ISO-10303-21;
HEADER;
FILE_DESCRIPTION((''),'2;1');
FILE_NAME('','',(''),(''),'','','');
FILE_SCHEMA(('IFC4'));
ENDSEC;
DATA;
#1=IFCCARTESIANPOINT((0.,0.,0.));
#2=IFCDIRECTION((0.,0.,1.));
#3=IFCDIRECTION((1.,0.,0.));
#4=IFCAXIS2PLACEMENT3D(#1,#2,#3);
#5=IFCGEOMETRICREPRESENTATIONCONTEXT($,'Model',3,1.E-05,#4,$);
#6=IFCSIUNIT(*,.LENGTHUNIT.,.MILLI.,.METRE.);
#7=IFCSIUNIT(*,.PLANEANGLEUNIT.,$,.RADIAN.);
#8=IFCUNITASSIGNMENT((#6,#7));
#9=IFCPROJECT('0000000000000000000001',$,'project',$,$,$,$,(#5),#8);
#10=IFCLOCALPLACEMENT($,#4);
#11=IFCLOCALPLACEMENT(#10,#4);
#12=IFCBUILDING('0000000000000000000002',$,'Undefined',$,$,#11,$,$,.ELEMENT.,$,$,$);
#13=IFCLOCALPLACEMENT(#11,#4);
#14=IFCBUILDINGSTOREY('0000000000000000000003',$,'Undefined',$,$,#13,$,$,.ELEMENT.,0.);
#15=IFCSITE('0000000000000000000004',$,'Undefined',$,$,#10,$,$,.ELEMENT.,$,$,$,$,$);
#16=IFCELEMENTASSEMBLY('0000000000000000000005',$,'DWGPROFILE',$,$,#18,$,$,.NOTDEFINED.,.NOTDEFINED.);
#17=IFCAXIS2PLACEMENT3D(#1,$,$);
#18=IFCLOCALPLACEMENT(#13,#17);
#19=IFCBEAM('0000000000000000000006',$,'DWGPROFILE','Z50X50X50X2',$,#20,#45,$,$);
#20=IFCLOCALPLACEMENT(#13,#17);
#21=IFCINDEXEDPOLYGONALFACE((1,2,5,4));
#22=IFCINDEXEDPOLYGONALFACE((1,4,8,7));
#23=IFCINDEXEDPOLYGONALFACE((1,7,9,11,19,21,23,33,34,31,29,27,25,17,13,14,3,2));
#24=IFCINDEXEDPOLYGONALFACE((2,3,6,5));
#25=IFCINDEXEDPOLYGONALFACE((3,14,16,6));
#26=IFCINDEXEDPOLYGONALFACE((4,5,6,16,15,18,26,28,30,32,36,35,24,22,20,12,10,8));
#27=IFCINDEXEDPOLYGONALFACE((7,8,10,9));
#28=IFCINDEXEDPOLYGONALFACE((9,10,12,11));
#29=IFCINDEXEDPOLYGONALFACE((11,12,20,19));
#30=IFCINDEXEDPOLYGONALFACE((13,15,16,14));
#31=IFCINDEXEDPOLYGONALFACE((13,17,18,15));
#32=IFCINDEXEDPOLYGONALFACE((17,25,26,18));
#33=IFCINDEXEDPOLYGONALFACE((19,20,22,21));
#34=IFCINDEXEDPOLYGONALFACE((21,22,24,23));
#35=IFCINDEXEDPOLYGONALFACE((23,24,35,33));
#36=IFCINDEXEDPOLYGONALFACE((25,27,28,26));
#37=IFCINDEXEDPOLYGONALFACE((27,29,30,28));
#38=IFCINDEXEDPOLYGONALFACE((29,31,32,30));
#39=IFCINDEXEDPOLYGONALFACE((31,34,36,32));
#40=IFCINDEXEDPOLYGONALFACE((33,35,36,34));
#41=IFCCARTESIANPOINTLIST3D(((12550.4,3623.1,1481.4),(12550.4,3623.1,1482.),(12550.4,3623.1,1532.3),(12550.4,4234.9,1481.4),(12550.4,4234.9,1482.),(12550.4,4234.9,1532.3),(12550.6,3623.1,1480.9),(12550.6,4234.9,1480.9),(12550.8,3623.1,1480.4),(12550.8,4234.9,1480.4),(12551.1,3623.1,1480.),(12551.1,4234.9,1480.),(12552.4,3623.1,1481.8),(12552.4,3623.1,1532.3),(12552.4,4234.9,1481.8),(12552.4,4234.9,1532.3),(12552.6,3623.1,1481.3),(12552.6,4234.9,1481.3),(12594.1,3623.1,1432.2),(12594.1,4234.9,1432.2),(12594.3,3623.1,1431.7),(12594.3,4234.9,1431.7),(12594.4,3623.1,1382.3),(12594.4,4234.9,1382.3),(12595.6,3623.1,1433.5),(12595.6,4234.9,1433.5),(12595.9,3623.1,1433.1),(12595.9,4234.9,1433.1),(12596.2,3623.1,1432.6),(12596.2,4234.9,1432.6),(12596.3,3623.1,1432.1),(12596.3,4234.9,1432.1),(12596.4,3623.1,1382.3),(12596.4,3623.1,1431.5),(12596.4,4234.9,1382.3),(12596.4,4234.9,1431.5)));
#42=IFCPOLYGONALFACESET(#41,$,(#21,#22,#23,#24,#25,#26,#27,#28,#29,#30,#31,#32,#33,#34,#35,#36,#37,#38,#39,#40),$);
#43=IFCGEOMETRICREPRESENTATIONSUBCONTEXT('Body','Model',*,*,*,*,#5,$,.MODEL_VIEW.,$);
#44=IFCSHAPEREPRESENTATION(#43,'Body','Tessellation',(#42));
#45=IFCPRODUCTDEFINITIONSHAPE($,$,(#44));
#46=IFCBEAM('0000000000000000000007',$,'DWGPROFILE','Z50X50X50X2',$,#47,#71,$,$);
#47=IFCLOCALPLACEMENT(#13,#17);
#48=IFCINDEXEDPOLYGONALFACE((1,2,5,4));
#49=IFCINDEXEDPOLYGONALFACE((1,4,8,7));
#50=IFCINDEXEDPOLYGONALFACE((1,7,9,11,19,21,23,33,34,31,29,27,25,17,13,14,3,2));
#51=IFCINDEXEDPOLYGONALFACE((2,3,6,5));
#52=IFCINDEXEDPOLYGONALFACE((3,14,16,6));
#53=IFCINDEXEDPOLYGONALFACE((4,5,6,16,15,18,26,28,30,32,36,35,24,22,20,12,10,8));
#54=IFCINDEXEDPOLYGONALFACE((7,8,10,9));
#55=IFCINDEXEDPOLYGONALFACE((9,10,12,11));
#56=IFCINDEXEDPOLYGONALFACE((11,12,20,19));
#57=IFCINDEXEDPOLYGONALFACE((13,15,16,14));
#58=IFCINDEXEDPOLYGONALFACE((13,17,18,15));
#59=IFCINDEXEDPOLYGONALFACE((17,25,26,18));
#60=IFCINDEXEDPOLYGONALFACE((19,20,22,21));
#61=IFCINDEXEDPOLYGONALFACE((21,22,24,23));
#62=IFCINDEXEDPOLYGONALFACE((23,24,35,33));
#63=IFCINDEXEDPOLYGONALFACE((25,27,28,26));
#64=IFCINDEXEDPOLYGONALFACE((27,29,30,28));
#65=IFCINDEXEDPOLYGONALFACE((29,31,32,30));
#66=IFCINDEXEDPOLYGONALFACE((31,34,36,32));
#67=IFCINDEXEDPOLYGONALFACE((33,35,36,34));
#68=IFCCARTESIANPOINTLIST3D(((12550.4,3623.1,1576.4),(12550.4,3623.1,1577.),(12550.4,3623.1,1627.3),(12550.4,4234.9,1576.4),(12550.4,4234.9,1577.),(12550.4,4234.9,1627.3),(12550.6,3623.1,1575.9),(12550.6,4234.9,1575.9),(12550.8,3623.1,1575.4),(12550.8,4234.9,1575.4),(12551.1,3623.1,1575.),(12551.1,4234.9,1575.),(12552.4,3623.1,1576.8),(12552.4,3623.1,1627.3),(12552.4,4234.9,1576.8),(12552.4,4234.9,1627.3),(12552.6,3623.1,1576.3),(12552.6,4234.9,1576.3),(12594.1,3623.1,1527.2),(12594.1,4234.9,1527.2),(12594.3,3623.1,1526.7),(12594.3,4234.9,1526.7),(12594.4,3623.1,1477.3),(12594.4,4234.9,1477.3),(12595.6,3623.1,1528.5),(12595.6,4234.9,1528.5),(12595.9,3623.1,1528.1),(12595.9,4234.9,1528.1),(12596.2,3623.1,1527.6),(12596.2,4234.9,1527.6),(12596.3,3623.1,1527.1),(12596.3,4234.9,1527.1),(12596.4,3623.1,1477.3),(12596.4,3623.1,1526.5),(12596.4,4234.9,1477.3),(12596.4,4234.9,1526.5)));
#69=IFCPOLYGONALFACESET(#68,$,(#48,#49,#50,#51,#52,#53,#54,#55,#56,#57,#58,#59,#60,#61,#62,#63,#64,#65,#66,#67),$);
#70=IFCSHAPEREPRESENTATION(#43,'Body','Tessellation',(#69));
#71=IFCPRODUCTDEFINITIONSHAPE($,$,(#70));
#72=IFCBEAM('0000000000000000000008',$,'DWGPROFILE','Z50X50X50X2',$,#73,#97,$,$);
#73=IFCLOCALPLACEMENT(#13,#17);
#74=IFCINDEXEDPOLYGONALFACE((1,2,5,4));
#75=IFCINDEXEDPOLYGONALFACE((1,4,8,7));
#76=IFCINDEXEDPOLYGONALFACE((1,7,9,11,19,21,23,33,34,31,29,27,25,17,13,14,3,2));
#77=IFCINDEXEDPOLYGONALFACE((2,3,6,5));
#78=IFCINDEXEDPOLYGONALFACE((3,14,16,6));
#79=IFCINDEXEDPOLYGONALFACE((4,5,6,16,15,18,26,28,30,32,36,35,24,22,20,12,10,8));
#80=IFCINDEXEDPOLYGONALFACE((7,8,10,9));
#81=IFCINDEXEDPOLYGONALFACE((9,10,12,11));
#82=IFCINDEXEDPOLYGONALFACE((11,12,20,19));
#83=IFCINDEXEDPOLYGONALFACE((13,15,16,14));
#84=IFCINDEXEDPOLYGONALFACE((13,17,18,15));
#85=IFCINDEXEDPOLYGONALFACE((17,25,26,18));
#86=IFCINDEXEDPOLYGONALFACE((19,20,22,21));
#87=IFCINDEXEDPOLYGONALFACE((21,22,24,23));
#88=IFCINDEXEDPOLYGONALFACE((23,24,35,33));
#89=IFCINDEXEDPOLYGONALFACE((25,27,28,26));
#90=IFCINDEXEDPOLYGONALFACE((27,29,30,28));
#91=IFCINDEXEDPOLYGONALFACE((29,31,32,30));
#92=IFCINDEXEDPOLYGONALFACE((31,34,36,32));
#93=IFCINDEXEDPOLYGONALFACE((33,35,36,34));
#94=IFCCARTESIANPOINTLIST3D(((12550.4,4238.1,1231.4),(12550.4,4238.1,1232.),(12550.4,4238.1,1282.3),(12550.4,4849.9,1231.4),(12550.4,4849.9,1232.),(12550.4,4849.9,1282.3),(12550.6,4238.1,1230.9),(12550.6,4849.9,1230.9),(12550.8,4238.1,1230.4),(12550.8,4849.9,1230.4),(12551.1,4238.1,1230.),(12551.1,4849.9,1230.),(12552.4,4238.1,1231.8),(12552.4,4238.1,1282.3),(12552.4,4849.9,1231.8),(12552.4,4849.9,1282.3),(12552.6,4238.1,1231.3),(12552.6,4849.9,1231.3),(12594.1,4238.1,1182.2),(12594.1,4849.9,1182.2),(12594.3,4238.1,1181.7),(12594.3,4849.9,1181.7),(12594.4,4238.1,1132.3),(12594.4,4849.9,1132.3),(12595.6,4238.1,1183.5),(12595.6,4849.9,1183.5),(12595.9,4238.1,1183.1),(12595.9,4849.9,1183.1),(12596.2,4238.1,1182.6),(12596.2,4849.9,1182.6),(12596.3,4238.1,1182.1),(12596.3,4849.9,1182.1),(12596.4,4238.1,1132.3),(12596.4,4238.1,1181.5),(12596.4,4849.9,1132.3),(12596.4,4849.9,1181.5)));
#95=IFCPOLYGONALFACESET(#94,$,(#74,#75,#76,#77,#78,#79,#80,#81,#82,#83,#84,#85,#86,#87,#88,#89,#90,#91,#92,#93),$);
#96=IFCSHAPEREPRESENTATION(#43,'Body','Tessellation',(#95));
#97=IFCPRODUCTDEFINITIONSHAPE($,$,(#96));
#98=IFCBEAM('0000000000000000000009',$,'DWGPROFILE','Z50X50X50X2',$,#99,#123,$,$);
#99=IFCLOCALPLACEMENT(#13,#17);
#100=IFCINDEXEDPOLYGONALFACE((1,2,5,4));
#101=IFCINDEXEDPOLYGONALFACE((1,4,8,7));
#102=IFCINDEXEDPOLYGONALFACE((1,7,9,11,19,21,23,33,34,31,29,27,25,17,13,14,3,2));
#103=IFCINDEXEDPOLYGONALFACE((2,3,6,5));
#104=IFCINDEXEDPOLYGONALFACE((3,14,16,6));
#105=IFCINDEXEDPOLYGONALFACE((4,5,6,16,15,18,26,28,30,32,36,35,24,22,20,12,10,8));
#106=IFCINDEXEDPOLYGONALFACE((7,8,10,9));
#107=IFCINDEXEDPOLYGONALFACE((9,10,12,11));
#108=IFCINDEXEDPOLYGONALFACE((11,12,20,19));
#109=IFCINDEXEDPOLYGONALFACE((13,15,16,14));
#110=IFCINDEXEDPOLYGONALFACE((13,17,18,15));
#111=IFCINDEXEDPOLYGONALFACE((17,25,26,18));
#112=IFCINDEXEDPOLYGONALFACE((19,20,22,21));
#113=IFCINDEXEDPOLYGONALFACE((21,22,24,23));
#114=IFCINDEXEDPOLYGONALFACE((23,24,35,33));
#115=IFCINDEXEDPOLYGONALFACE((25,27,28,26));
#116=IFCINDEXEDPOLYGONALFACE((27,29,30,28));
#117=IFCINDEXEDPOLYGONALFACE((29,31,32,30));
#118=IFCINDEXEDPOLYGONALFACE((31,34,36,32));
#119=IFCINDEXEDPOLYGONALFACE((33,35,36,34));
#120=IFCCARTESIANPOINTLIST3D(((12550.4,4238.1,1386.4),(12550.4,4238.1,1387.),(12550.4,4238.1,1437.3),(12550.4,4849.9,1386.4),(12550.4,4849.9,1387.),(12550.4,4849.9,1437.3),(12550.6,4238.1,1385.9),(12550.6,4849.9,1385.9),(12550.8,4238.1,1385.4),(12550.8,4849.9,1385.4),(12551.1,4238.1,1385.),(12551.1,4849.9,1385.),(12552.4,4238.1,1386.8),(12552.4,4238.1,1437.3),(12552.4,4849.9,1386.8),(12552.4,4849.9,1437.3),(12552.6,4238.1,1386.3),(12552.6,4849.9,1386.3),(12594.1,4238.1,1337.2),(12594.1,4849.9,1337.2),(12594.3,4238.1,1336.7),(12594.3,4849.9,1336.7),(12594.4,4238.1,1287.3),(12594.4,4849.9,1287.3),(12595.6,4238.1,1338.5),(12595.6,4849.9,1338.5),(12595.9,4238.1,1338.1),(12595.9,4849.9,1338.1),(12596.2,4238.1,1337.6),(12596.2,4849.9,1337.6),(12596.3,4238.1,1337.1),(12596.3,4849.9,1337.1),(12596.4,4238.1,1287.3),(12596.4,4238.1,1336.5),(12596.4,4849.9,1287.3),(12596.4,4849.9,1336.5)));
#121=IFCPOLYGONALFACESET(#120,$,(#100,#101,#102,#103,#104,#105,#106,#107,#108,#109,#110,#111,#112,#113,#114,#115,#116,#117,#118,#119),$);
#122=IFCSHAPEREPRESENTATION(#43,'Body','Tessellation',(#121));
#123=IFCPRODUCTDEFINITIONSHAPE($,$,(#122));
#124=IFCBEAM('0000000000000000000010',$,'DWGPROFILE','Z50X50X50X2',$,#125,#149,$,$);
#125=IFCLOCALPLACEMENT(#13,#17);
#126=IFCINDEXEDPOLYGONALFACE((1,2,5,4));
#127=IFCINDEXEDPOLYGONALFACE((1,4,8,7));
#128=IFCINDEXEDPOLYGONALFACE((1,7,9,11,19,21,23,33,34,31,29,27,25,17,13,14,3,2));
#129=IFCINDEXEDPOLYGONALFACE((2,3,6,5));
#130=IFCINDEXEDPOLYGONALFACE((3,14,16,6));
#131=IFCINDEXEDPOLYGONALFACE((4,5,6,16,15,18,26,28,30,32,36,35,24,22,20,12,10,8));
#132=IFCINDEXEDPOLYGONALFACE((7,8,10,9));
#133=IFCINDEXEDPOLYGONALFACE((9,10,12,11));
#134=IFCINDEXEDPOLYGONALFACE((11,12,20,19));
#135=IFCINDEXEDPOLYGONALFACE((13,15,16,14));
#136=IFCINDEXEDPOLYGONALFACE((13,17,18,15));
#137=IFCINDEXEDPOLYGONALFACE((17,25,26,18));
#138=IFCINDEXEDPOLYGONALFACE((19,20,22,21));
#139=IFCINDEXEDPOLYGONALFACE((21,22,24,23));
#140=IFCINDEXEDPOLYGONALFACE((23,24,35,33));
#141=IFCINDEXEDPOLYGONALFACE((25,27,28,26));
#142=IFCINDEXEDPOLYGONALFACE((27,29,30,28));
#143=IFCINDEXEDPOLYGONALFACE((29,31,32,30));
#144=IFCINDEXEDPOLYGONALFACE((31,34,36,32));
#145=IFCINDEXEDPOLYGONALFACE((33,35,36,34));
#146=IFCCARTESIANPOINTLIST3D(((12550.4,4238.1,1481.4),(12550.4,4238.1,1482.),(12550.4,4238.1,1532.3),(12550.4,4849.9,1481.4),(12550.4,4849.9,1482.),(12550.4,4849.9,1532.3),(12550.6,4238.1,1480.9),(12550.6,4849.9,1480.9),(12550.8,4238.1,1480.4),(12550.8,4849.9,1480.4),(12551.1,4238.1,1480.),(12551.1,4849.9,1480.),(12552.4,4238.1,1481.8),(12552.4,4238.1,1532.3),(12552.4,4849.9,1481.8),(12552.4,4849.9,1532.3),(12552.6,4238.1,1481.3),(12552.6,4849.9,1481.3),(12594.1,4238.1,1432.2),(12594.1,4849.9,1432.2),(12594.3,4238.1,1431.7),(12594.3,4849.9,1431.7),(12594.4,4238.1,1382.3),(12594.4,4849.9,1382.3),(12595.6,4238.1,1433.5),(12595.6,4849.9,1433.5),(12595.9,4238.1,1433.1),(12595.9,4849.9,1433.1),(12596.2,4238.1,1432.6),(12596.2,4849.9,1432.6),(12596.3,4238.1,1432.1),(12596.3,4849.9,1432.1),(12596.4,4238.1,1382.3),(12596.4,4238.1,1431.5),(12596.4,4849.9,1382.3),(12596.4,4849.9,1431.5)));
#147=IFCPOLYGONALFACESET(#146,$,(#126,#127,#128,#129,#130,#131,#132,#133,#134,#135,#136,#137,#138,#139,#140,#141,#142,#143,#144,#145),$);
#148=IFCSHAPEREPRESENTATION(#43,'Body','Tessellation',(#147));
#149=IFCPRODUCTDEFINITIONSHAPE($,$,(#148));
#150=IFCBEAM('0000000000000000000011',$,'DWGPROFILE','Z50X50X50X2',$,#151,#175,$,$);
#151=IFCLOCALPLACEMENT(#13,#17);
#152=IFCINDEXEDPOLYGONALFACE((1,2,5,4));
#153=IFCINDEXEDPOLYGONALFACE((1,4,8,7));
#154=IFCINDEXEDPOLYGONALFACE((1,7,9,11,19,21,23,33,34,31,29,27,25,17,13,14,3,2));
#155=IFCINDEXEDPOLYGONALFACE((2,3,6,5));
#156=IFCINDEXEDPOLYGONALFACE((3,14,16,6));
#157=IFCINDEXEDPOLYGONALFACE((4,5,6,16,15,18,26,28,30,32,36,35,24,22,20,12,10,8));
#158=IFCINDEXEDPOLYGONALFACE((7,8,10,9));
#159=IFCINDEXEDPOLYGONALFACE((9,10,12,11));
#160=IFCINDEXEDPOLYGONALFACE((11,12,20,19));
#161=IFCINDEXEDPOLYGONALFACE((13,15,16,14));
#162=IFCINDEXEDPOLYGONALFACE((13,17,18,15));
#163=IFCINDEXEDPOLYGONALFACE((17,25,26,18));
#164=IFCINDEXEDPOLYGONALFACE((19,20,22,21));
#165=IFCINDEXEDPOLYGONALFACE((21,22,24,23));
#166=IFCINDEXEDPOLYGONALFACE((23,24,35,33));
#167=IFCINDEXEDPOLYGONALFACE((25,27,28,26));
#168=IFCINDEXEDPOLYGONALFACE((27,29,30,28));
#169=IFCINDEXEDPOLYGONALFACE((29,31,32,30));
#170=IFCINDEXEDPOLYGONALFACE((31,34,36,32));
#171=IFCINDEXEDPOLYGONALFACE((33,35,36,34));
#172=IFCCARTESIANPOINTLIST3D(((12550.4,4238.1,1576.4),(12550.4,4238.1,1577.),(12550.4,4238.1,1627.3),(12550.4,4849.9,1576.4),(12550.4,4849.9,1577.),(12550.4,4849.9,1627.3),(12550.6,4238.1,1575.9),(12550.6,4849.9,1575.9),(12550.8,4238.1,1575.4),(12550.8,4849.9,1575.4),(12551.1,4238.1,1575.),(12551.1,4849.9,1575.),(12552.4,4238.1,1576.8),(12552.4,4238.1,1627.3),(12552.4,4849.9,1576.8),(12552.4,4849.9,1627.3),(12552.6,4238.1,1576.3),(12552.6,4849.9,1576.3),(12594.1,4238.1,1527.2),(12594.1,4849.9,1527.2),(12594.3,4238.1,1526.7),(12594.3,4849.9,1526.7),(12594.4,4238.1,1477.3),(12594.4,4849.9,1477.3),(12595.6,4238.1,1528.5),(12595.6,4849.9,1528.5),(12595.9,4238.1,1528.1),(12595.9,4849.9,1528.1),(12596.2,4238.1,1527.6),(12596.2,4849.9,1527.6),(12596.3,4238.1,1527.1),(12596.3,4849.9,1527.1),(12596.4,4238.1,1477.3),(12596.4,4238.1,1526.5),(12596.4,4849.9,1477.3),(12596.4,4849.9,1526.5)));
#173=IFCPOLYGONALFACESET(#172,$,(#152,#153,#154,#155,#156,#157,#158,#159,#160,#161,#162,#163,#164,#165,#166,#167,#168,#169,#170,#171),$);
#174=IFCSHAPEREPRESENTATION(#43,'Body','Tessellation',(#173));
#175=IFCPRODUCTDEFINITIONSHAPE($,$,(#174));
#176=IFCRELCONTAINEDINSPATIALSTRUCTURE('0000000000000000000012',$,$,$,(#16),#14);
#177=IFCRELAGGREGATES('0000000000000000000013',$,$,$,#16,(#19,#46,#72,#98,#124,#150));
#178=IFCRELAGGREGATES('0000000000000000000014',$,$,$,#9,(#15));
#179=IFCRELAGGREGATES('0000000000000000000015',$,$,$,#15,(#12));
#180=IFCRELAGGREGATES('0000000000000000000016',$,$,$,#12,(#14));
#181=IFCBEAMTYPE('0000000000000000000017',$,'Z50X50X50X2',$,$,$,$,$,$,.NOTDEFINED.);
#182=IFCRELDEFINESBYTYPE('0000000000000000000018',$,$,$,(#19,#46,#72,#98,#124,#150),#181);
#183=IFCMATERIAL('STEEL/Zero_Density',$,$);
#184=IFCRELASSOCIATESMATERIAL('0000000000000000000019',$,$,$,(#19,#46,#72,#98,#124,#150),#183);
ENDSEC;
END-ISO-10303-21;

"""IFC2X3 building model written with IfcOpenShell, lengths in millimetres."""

from ifc_helpers import new_model, si_unit, frame, origin_with_axes, place, context, subcontext, project, spatial, polyline, outline, extrude, material, type_object, element, aggregate, save


model = new_model("IFC2X3")

# Units and contexts
model_context = context("Model", 3, precision=1e-05, world=origin_with_axes())
body_context = subcontext(model_context, "Body", "Model", "MODEL_VIEW")
ifc_project = project(units=[si_unit("LENGTHUNIT", "METRE", prefix="MILLI"), si_unit("PLANEANGLEUNIT", "RADIAN")], contexts=[model_context])

# Site, building, storey
site_placement = place(None, origin_with_axes())
site = spatial("IfcSite", under=ifc_project, at=site_placement, Name="Undefined", CompositionType="ELEMENT")
building_placement = place(site_placement, origin_with_axes())
building = spatial("IfcBuilding", under=site, at=building_placement, Name="Undefined", CompositionType="ELEMENT")
storey_placement = place(building_placement, origin_with_axes())
storey = spatial("IfcBuildingStorey", under=building, at=storey_placement, Name="Undefined", CompositionType="ELEMENT", Elevation=0.0)

# Element assembly, beams
assembly_1_placement = place(storey_placement, origin_with_axes())
assembly_1 = element("IfcElementAssembly", 1, at=assembly_1_placement, inside=storey, Name="DWGPROFILE", AssemblyPlace="NOTDEFINED", PredefinedType="NOTDEFINED")
ifc_material_1 = material(Name="STEEL/Zero_Density")
beam_type_1 = type_object("IfcBeamType", Name="Z50X50X50X2", PredefinedType="NOTDEFINED")
beam_1_placement = place(assembly_1_placement, frame((12573.4, 3623.1, 1457.3), z_axis=(0.0, 0.0, 1.0), x_axis=(0.0, 1.0, 0.0)))
beam_1 = element("IfcBeam", 2, at=beam_1_placement, type_object=beam_type_1, material=ifc_material_1, Name="DWGPROFILE", Description="Z50X50X50X2", context=body_context, shape_type="SweptSolid", body=[
    extrude(outline(polyline([(-22.9, 24.1), (-23.0, 24.7), (-23.0, 75.0), (-21.0, 75.0), (-21.0, 24.5), (-20.7, 24.0), (22.2, -23.8), (22.6, -24.2), (22.8, -24.7), (22.9, -25.2), (23.0, -25.8), (23.0, -75.0), (21.0, -75.0), (21.0, -25.6), (20.7, -25.1), (-22.2, 22.6), (-22.6, 23.1), (-22.8, 23.6), (-22.9, 24.1)])), frame((611.8, 0.0, 0.0), z_axis=(-1.0, 0.0, 0.0), x_axis=(0.0, -1.0, 0.0)), (0.0, 0.0, 1.0), 611.8),
])
beam_2_placement = place(assembly_1_placement, frame((12573.4, 3623.1, 1552.3), z_axis=(0.0, 0.0, 1.0), x_axis=(0.0, 1.0, 0.0)))
beam_2 = element("IfcBeam", 3, at=beam_2_placement, type_object=beam_type_1, material=ifc_material_1, Name="DWGPROFILE", Description="Z50X50X50X2", context=body_context, shape_type="SweptSolid", body=[
    extrude(outline(polyline([(-22.9, 24.1), (-23.0, 24.7), (-23.0, 75.0), (-21.0, 75.0), (-21.0, 24.5), (-20.7, 24.0), (22.2, -23.8), (22.6, -24.2), (22.8, -24.7), (22.9, -25.2), (23.0, -25.8), (23.0, -75.0), (21.0, -75.0), (21.0, -25.6), (20.7, -25.1), (-22.2, 22.6), (-22.6, 23.1), (-22.8, 23.6), (-22.9, 24.1)])), frame((611.8, 0.0, 0.0), z_axis=(-1.0, 0.0, 0.0), x_axis=(0.0, -1.0, 0.0)), (0.0, 0.0, 1.0), 611.8),
])
beam_3_placement = place(assembly_1_placement, frame((12573.4, 4238.1, 1207.3), z_axis=(0.0, 0.0, 1.0), x_axis=(0.0, 1.0, 0.0)))
beam_3 = element("IfcBeam", 4, at=beam_3_placement, type_object=beam_type_1, material=ifc_material_1, Name="DWGPROFILE", Description="Z50X50X50X2", context=body_context, shape_type="SweptSolid", body=[
    extrude(outline(polyline([(-22.9, 24.1), (-23.0, 24.7), (-23.0, 75.0), (-21.0, 75.0), (-21.0, 24.5), (-20.7, 24.0), (22.2, -23.8), (22.6, -24.2), (22.8, -24.7), (22.9, -25.2), (23.0, -25.8), (23.0, -75.0), (21.0, -75.0), (21.0, -25.6), (20.7, -25.1), (-22.2, 22.6), (-22.6, 23.1), (-22.8, 23.6), (-22.9, 24.1)])), frame((611.8, 0.0, 0.0), z_axis=(-1.0, 0.0, 0.0), x_axis=(0.0, -1.0, 0.0)), (0.0, 0.0, 1.0), 611.8),
])
beam_4_placement = place(assembly_1_placement, frame((12573.4, 4238.1, 1362.3), z_axis=(0.0, 0.0, 1.0), x_axis=(0.0, 1.0, 0.0)))
beam_4 = element("IfcBeam", 5, at=beam_4_placement, type_object=beam_type_1, material=ifc_material_1, Name="DWGPROFILE", Description="Z50X50X50X2", context=body_context, shape_type="SweptSolid", body=[
    extrude(outline(polyline([(-22.9, 24.1), (-23.0, 24.7), (-23.0, 75.0), (-21.0, 75.0), (-21.0, 24.5), (-20.7, 24.0), (22.2, -23.8), (22.6, -24.2), (22.8, -24.7), (22.9, -25.2), (23.0, -25.8), (23.0, -75.0), (21.0, -75.0), (21.0, -25.6), (20.7, -25.1), (-22.2, 22.6), (-22.6, 23.1), (-22.8, 23.6), (-22.9, 24.1)])), frame((611.8, 0.0, 0.0), z_axis=(-1.0, 0.0, 0.0), x_axis=(0.0, -1.0, 0.0)), (0.0, 0.0, 1.0), 611.8),
])
beam_5_placement = place(assembly_1_placement, frame((12573.4, 4238.1, 1457.3), z_axis=(0.0, 0.0, 1.0), x_axis=(0.0, 1.0, 0.0)))
beam_5 = element("IfcBeam", 6, at=beam_5_placement, type_object=beam_type_1, material=ifc_material_1, Name="DWGPROFILE", Description="Z50X50X50X2", context=body_context, shape_type="SweptSolid", body=[
    extrude(outline(polyline([(-22.9, 24.1), (-23.0, 24.7), (-23.0, 75.0), (-21.0, 75.0), (-21.0, 24.5), (-20.7, 24.0), (22.2, -23.8), (22.6, -24.2), (22.8, -24.7), (22.9, -25.2), (23.0, -25.8), (23.0, -75.0), (21.0, -75.0), (21.0, -25.6), (20.7, -25.1), (-22.2, 22.6), (-22.6, 23.1), (-22.8, 23.6), (-22.9, 24.1)])), frame((611.8, 0.0, 0.0), z_axis=(-1.0, 0.0, 0.0), x_axis=(0.0, -1.0, 0.0)), (0.0, 0.0, 1.0), 611.8),
])
beam_6_placement = place(assembly_1_placement, frame((12573.4, 4238.1, 1552.3), z_axis=(0.0, 0.0, 1.0), x_axis=(0.0, 1.0, 0.0)))
beam_6 = element("IfcBeam", 7, at=beam_6_placement, type_object=beam_type_1, material=ifc_material_1, Name="DWGPROFILE", Description="Z50X50X50X2", context=body_context, shape_type="SweptSolid", body=[
    extrude(outline(polyline([(-22.9, 24.1), (-23.0, 24.7), (-23.0, 75.0), (-21.0, 75.0), (-21.0, 24.5), (-20.7, 24.0), (22.2, -23.8), (22.6, -24.2), (22.8, -24.7), (22.9, -25.2), (23.0, -25.8), (23.0, -75.0), (21.0, -75.0), (21.0, -25.6), (20.7, -25.1), (-22.2, 22.6), (-22.6, 23.1), (-22.8, 23.6), (-22.9, 24.1)])), frame((611.8, 0.0, 0.0), z_axis=(-1.0, 0.0, 0.0), x_axis=(0.0, -1.0, 0.0)), (0.0, 0.0, 1.0), 611.8),
])
aggregate(assembly_1, [beam_1, beam_2, beam_3, beam_4, beam_5, beam_6])

save(model, "model.ifc")
